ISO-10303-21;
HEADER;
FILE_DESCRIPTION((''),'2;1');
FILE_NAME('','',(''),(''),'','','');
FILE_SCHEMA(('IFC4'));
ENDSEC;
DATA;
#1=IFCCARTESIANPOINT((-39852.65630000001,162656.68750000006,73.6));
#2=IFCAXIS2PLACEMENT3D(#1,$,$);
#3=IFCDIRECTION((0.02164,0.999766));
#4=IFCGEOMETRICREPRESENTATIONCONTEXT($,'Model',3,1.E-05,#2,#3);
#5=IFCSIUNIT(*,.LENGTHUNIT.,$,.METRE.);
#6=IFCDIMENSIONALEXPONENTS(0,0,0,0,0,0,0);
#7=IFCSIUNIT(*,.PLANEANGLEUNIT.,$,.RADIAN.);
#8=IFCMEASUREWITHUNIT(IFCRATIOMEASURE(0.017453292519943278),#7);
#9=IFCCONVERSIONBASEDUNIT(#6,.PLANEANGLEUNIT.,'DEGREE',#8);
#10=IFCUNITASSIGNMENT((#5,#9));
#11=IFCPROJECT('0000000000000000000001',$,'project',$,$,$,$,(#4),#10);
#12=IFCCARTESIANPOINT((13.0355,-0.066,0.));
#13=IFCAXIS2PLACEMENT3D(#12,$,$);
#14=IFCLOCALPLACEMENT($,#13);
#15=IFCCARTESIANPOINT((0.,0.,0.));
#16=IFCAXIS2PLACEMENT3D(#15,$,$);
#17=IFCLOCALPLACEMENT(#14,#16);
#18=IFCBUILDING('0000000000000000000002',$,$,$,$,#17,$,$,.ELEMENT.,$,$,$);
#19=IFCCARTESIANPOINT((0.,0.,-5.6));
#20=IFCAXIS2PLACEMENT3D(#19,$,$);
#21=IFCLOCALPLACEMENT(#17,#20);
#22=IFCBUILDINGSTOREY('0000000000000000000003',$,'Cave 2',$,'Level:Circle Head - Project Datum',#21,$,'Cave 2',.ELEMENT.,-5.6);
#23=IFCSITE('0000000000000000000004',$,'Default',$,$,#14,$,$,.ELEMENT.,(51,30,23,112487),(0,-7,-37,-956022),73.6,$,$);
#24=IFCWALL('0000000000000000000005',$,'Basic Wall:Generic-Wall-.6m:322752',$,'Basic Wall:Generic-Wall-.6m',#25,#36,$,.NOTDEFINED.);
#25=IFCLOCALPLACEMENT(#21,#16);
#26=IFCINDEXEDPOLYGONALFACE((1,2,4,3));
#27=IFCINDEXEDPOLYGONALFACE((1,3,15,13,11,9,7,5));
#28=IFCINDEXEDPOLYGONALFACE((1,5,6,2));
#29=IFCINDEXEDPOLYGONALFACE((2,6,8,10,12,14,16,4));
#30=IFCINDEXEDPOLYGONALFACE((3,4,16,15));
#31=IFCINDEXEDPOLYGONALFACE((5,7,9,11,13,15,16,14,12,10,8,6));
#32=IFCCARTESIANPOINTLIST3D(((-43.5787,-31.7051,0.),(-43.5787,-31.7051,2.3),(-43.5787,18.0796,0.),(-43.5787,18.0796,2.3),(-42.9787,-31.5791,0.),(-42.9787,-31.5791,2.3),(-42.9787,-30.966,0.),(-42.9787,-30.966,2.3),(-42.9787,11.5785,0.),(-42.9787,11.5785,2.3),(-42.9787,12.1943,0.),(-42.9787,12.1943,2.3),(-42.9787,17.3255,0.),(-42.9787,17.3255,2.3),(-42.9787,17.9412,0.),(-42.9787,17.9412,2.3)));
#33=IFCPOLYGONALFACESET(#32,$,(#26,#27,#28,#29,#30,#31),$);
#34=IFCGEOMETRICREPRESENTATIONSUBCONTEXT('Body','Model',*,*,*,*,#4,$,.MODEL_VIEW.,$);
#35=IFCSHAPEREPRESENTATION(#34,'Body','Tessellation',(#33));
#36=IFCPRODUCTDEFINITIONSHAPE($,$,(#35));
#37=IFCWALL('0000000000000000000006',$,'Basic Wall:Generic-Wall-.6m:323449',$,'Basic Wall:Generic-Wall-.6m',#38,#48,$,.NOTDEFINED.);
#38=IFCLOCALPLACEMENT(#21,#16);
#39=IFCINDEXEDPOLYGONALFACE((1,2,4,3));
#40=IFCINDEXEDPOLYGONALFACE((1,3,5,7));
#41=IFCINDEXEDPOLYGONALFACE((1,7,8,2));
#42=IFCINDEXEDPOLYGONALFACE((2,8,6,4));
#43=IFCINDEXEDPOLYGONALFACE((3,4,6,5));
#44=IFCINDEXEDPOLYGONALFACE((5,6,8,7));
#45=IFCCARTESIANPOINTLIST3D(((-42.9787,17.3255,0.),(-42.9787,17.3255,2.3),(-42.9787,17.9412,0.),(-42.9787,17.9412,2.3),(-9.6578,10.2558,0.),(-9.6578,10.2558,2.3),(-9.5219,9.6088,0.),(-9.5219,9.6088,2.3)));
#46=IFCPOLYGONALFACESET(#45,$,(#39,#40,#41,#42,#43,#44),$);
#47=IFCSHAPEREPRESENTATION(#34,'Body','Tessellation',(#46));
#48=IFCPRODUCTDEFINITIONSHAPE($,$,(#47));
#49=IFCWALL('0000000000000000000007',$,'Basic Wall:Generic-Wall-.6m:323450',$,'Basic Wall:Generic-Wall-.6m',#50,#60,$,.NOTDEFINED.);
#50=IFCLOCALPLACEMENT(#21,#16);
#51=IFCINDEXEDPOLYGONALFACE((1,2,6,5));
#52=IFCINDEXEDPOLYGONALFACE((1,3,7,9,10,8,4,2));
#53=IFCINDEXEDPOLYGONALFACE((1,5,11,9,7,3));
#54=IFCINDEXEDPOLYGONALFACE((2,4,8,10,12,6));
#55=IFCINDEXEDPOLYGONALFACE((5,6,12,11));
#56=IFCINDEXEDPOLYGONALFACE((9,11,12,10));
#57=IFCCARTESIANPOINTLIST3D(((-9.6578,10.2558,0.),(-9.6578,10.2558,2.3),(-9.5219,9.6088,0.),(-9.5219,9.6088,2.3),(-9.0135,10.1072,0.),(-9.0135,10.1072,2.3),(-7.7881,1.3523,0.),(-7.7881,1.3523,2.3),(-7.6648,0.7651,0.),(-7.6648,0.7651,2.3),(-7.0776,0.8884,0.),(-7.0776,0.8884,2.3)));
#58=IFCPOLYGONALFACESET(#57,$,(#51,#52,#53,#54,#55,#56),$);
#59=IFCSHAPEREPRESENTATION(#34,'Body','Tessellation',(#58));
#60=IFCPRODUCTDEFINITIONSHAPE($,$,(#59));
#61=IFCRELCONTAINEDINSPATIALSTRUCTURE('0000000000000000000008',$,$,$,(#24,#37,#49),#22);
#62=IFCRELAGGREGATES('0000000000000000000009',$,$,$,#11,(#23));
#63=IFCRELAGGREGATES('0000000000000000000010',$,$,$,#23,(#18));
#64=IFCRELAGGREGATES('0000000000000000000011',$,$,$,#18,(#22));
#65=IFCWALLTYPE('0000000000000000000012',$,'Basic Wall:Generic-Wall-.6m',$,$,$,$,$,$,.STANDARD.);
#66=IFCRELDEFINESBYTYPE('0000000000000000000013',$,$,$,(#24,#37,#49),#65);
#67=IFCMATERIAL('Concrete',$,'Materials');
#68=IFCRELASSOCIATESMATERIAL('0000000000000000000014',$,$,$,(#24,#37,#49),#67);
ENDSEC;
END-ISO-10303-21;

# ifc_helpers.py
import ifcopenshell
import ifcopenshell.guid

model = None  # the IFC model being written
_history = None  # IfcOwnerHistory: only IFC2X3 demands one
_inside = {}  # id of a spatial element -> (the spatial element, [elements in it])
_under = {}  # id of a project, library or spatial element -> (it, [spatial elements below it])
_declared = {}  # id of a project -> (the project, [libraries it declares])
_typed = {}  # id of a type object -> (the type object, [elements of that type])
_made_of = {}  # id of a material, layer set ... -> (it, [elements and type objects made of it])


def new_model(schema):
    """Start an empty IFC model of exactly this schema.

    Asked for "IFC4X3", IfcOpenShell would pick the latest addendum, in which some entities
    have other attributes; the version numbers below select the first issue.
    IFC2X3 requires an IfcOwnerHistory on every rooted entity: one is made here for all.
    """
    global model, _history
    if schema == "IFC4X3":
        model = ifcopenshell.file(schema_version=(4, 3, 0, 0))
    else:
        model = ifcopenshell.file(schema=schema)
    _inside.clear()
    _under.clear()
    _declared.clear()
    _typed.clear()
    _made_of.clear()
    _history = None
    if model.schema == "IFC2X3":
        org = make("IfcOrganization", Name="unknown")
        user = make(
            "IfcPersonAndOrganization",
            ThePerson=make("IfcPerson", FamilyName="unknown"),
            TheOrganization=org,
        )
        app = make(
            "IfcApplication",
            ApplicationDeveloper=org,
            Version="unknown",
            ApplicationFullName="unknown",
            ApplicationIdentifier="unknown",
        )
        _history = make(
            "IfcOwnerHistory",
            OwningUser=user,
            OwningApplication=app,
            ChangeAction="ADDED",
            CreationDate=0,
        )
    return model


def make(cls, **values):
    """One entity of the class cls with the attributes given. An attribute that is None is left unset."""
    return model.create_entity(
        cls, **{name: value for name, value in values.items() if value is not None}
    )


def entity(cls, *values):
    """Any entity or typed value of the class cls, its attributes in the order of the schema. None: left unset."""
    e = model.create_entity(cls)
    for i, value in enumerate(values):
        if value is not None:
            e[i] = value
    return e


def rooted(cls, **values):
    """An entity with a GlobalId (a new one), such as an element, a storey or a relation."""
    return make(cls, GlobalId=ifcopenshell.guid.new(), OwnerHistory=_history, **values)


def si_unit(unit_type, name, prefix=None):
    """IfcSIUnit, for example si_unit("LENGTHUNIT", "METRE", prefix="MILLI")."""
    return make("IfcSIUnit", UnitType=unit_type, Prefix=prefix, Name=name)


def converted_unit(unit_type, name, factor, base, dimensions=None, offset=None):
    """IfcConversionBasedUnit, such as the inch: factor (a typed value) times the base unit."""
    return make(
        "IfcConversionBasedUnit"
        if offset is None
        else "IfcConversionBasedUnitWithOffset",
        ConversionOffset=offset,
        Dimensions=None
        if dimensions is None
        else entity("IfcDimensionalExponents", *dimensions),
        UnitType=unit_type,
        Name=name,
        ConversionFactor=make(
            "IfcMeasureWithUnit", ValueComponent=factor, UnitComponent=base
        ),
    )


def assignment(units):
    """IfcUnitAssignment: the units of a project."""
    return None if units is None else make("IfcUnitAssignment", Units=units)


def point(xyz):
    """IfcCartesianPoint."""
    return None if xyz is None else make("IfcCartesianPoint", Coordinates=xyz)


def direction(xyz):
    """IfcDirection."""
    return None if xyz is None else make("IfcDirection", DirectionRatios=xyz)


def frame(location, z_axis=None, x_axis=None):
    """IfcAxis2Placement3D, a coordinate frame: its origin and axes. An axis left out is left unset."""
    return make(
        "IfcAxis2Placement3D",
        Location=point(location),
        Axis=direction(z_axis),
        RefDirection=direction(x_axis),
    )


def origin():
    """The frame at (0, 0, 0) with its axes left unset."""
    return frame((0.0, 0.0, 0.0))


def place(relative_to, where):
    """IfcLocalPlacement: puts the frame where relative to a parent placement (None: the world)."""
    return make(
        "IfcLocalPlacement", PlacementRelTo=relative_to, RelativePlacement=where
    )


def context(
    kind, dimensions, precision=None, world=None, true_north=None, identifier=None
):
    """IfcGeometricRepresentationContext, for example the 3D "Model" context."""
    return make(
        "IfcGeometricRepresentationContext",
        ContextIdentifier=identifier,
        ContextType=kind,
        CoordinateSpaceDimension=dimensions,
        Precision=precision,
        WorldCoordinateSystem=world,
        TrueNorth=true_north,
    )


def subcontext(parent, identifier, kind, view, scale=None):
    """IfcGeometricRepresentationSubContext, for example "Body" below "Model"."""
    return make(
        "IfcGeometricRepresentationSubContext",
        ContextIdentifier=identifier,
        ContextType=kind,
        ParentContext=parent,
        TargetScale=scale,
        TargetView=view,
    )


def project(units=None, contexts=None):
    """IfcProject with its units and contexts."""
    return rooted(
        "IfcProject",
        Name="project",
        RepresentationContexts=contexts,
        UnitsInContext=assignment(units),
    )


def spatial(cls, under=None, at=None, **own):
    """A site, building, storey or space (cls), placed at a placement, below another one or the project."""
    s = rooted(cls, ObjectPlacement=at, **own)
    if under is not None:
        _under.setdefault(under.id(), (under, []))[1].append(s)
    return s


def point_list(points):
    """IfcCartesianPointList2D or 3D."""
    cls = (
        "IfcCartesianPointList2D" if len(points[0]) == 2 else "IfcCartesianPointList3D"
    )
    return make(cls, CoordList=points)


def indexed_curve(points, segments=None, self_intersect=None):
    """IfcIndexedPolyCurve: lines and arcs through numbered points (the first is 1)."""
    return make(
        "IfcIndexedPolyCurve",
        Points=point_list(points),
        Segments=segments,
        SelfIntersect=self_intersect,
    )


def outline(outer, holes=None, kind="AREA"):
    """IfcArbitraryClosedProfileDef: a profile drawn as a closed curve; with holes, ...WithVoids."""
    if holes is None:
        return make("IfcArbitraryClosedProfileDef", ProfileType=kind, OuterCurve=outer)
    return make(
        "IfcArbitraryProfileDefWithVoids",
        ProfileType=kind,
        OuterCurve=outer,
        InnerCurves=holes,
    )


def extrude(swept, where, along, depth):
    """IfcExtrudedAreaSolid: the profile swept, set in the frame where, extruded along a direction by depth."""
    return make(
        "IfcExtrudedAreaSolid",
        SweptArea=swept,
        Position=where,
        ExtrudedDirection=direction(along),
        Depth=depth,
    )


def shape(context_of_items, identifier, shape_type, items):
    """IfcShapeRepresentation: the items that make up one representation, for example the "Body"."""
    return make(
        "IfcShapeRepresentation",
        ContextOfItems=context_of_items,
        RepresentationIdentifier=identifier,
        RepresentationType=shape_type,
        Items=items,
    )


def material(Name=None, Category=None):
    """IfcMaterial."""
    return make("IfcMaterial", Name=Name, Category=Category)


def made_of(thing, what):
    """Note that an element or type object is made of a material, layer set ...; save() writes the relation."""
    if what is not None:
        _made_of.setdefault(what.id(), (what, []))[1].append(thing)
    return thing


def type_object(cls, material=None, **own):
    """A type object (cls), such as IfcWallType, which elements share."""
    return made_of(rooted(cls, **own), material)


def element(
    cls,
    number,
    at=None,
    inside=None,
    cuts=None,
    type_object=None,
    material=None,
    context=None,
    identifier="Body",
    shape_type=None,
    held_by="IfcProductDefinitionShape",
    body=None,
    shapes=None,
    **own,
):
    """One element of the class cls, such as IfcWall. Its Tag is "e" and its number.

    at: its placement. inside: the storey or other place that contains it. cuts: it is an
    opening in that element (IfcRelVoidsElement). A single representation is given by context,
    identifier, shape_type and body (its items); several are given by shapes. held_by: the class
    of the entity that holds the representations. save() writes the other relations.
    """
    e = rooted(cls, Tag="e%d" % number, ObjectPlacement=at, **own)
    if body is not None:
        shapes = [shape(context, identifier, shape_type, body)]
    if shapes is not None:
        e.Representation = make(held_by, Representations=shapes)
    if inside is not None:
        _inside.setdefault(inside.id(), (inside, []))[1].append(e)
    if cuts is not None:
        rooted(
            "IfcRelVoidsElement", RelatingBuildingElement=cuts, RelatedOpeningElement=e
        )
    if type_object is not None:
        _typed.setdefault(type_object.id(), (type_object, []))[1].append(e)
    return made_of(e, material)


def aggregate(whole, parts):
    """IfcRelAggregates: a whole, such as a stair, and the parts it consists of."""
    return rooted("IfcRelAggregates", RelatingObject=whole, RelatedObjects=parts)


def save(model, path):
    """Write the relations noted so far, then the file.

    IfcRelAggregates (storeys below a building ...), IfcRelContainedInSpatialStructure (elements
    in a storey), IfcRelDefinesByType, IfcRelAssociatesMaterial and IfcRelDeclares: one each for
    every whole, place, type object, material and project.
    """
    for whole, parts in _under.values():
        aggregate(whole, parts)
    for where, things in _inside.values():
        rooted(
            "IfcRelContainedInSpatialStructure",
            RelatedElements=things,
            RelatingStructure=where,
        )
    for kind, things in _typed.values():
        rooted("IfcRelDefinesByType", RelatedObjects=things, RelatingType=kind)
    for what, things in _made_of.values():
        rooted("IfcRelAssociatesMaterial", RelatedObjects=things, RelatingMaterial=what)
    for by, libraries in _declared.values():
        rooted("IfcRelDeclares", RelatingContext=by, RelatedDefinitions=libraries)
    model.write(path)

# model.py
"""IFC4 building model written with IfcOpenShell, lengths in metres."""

from ifc_helpers import new_model, entity, si_unit, converted_unit, direction, frame, origin, place, context, subcontext, project, spatial, indexed_curve, outline, extrude, material, type_object, element, save


model = new_model("IFC4")

# Units and contexts
model_context = context("Model", 3, precision=1e-05, world=frame((-39852.65630000001, 162656.68750000006, 73.6)), true_north=direction((0.02164, 0.999766)))
body_context = subcontext(model_context, "Body", "Model", "MODEL_VIEW")
ifc_project = project(units=[si_unit("LENGTHUNIT", "METRE"), converted_unit("PLANEANGLEUNIT", "DEGREE", entity("IfcRatioMeasure", 0.017453292519943278), si_unit("PLANEANGLEUNIT", "RADIAN"), dimensions=[0, 0, 0, 0, 0, 0, 0])], contexts=[model_context])

# Site, building, storey
site_placement = place(None, frame((13.0355, -0.066, 0.0)))
site = spatial("IfcSite", under=ifc_project, at=site_placement, Name="Default", CompositionType="ELEMENT", RefLatitude=(51, 30, 23, 112487), RefLongitude=(0, -7, -37, -956022), RefElevation=73.6)
building_placement = place(site_placement, origin())
building = spatial("IfcBuilding", under=site, at=building_placement, CompositionType="ELEMENT")
storey_placement = place(building_placement, frame((0.0, 0.0, -5.6)))
storey = spatial("IfcBuildingStorey", under=building, at=storey_placement, Name="Cave 2", ObjectType="Level:Circle Head - Project Datum", LongName="Cave 2", CompositionType="ELEMENT", Elevation=-5.6)

# Shared definitions
ifc_material = material(Name="Concrete", Category="Materials")

# Walls
wall_type = type_object("IfcWallType", Name="Basic Wall:Generic-Wall-.6m", PredefinedType="STANDARD")
wall_1_placement = place(storey_placement, frame((-43.2787, -31.7051, 0.0), z_axis=(0.0, 0.0, 1.0), x_axis=(0.0, 1.0, 0.0)))
element("IfcWall", 1, at=wall_1_placement, inside=storey, type_object=wall_type, material=ifc_material, Name="Basic Wall:Generic-Wall-.6m:322752", ObjectType="Basic Wall:Generic-Wall-.6m", PredefinedType="NOTDEFINED", context=body_context, shape_type="SweptSolid", body=[
    extrude(outline(indexed_curve([(49.6463, -0.3), (49.7847, 0.3), (0.0, 0.3), (0.126, -0.3), (0.7391, -0.3), (43.2836, -0.3), (43.8994, -0.3), (49.0305, -0.3), (49.6463, -0.3)], self_intersect=False)), origin(), (0.0, 0.0, 1.0), 2.3),
])
wall_2_placement = place(storey_placement, frame((-43.0461, 17.6489, 0.0), z_axis=(0.0, 0.0, 1.0), x_axis=(0.974417, -0.224746, 0.0)))
element("IfcWall", 2, at=wall_2_placement, inside=storey, type_object=wall_type, material=ifc_material, Name="Basic Wall:Generic-Wall-.6m:323449", ObjectType="Basic Wall:Generic-Wall-.6m", PredefinedType="NOTDEFINED", context=body_context, shape_type="SweptSolid", body=[
    extrude(outline(indexed_curve([(34.4735, -0.3), (34.1957, 0.3), (0.0, 0.3), (0.1384, -0.3), (34.4735, -0.3)], self_intersect=False)), origin(), (0.0, 0.0, 1.0), 2.3),
])
wall_3_placement = place(storey_placement, frame((-9.3642, 10.3175, 0.0), z_axis=(0.0, 0.0, 1.0), x_axis=(0.20551, -0.978655, 0.0)))
element("IfcWall", 3, at=wall_3_placement, inside=storey, type_object=wall_type, material=ifc_material, Name="Basic Wall:Generic-Wall-.6m:323450", ObjectType="Basic Wall:Generic-Wall-.6m", PredefinedType="NOTDEFINED", context=body_context, shape_type="SweptSolid", body=[
    extrude(outline(indexed_curve([(9.6977, -0.3), (9.6977, 0.3), (0.2778, 0.3), (0.0, -0.3), (0.6612, -0.3), (9.0977, -0.3), (9.6977, -0.3)], self_intersect=False)), origin(), (0.0, 0.0, 1.0), 2.3),
])

save(model, "model.ifc")
